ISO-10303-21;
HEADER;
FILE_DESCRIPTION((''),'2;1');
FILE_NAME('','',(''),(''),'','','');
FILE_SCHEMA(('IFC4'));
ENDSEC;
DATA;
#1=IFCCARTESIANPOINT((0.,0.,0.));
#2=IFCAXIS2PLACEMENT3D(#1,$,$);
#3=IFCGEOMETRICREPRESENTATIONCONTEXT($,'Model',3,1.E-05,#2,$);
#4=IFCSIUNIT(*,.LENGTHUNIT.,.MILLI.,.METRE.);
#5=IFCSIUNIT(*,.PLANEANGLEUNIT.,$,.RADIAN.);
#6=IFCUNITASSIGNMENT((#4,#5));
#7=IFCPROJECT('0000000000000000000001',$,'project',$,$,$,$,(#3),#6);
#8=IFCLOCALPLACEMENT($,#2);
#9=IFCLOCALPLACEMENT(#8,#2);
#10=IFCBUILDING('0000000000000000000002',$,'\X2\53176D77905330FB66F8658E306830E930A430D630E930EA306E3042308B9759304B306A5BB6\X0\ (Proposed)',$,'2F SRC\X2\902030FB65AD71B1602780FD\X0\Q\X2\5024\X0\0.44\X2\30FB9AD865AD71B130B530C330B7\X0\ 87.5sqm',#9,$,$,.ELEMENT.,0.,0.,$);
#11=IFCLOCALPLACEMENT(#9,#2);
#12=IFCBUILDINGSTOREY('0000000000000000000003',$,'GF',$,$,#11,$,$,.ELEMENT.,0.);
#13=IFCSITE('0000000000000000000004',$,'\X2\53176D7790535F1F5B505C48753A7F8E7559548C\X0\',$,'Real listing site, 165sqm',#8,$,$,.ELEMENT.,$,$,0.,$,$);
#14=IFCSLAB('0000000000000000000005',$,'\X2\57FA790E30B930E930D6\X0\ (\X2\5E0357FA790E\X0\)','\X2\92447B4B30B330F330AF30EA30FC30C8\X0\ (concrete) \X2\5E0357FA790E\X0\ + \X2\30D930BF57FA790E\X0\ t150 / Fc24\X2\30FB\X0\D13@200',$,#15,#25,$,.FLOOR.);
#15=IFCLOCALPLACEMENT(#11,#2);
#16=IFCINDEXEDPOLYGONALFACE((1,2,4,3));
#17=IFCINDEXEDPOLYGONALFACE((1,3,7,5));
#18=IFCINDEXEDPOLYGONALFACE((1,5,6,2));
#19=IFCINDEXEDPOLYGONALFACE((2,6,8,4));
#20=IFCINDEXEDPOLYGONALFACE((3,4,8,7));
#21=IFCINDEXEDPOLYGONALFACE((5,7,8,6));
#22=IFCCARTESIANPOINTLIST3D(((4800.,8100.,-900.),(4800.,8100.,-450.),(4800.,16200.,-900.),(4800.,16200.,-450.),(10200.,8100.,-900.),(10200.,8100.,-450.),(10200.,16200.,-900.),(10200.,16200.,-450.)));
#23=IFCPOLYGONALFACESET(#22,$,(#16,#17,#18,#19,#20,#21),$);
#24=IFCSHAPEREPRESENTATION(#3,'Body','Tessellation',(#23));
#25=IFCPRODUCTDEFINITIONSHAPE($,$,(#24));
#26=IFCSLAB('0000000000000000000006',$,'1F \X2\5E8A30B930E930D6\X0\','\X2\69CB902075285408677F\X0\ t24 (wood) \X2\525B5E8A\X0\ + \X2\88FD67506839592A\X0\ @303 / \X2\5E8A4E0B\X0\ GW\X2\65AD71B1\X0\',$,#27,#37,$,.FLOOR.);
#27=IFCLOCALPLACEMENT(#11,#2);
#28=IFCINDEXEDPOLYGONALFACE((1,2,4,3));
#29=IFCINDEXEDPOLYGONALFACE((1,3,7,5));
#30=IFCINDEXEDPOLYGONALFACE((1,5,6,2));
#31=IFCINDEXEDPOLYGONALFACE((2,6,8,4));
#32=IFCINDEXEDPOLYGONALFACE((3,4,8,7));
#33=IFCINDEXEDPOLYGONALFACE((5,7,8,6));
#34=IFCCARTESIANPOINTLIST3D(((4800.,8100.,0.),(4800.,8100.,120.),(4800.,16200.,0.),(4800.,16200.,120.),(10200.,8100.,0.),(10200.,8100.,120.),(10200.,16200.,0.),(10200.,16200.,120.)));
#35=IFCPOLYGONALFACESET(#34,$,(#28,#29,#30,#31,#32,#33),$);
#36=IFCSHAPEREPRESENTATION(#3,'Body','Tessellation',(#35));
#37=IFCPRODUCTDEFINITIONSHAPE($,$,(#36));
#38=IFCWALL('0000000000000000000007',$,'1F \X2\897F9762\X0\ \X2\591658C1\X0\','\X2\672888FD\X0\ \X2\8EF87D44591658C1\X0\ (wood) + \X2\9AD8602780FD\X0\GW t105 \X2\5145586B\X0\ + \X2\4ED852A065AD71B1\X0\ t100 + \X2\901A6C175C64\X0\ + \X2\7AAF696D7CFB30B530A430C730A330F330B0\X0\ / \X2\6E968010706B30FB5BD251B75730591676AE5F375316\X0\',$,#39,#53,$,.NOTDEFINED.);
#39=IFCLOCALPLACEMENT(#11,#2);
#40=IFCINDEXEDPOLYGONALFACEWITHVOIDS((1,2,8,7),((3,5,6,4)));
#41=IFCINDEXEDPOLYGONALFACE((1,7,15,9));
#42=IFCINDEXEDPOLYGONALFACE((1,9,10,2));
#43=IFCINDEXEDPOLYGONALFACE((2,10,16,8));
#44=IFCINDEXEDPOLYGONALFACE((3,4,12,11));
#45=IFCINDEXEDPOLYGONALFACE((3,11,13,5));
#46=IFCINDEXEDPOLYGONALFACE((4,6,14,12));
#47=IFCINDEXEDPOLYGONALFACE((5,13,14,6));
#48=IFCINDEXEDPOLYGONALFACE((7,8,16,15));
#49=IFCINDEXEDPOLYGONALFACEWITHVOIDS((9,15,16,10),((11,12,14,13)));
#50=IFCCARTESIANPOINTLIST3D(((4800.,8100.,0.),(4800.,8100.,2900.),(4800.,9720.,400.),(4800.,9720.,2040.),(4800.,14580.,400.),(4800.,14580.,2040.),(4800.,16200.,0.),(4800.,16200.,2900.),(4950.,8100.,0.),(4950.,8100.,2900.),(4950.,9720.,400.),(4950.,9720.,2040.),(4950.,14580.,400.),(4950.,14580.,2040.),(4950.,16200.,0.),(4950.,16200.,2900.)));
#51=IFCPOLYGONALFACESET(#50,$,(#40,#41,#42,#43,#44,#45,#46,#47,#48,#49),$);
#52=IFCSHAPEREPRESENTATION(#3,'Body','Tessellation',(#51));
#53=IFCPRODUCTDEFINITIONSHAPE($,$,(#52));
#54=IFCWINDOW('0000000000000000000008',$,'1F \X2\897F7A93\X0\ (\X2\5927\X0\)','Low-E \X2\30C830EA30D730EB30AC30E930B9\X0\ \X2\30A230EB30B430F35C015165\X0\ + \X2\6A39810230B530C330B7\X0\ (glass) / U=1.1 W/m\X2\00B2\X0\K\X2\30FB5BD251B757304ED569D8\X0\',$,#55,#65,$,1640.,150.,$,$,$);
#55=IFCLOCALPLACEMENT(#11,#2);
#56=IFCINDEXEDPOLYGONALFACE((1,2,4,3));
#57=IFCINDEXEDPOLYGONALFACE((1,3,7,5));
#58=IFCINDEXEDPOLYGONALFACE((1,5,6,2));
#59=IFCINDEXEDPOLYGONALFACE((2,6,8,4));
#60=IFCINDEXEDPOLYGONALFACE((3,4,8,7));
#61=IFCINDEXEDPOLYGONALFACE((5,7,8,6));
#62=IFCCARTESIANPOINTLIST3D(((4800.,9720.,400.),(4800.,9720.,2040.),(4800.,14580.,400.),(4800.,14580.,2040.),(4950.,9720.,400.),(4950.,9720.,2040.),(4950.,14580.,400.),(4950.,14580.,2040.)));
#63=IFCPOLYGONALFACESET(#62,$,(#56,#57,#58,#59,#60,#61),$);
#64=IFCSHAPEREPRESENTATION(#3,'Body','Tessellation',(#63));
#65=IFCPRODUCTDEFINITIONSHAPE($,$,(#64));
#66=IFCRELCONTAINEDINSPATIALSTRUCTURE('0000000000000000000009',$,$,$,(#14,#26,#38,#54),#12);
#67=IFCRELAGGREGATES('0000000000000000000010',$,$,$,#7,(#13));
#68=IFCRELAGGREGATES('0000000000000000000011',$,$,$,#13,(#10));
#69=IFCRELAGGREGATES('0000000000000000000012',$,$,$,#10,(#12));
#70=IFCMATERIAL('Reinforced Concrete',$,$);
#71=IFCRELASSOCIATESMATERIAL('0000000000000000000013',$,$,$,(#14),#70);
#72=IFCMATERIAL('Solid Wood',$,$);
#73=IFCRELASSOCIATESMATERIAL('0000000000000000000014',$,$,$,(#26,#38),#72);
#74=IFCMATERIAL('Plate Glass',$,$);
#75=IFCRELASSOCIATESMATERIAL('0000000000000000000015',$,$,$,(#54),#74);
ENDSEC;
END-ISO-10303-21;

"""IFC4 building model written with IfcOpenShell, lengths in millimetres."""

from ifc_helpers import new_model, si_unit, frame, frame_2d, origin, place, context, project, spatial, rectangle, extrude, material, element, fill, save


model = new_model("IFC4")

# Units and contexts
model_context = context("Model", 3, precision=1e-05, world=origin())
ifc_project = project(units=[si_unit("LENGTHUNIT", "METRE", prefix="MILLI"), si_unit("PLANEANGLEUNIT", "RADIAN")], contexts=[model_context])

# Site, building, storey
site_placement = place(None, origin())
site = spatial("IfcSite", under=ifc_project, at=site_placement, Name="北海道弟子屈町美留和", ObjectType="Real listing site, 165sqm", CompositionType="ELEMENT", RefElevation=0.0)
building_placement = place(site_placement, origin())
building = spatial("IfcBuilding", under=site, at=building_placement, Name="北海道・書斎とライブラリのある静かな家 (Proposed)", ObjectType="2F SRC造・断熱性能Q値0.44・高断熱サッシ 87.5sqm", CompositionType="ELEMENT", ElevationOfRefHeight=0.0, ElevationOfTerrain=0.0)
storey_placement = place(building_placement, origin())
storey = spatial("IfcBuildingStorey", under=building, at=storey_placement, Name="GF", CompositionType="ELEMENT", Elevation=0.0)

# Shared definitions
ifc_material_1 = material(Name="Solid Wood")

# Slabs
ifc_material_2 = material(Name="Reinforced Concrete")
slab_1_placement = place(storey_placement, frame((2400.0, 4050.0, -450.0)))
element("IfcSlab", 1, at=slab_1_placement, inside=storey, material=ifc_material_2, Name="基礎スラブ (布基礎)", Description="鉄筋コンクリート (concrete) 布基礎 + ベタ基礎 t150 / Fc24・D13@200", PredefinedType="FLOOR", context=model_context, shape_type="SweptSolid", body=[
    extrude(rectangle(XDim=5400.0, YDim=8100.0, at=frame_2d((2700.0, 4050.0))), frame((2400.0, 4050.0, -450.0)), (0.0, 0.0, 1.0), 450.0),
])
slab_2_placement = place(storey_placement, frame((2400.0, 4050.0, 0.0)))
element("IfcSlab", 2, at=slab_2_placement, inside=storey, material=ifc_material_1, Name="1F 床スラブ", Description="構造用合板 t24 (wood) 剛床 + 製材根太 @303 / 床下 GW断熱", PredefinedType="FLOOR", context=model_context, shape_type="SweptSolid", body=[
    extrude(rectangle(XDim=5400.0, YDim=8100.0, at=frame_2d((2700.0, 4050.0))), frame((2400.0, 4050.0, 0.0)), (0.0, 0.0, 1.0), 120.0),
])

# Shared definitions
ifc_material_3 = material(Name="Plate Glass")

# Wall, opening, window
wall_1_placement = place(storey_placement, frame((2400.0, 4050.0, 0.0)))
wall_1 = element("IfcWall", 3, at=wall_1_placement, inside=storey, material=ifc_material_1, Name="1F 西面 外壁", Description="木製 軸組外壁 (wood) + 高性能GW t105 充填 + 付加断熱 t100 + 通気層 + 窯業系サイディング / 準耐火・寒冷地外皮強化", PredefinedType="NOTDEFINED", context=model_context, shape_type="SweptSolid", body=[
    extrude(rectangle(XDim=150.0, YDim=8100.0, at=frame_2d((75.0, 4050.0))), frame((2400.0, 4050.0, 0.0)), (0.0, 0.0, 1.0), 2900.0),
])
opening_1_placement = place(storey_placement, frame((2400.0, 4860.0, 200.0)))
opening_1 = element("IfcOpeningElement", 4, at=opening_1_placement, cuts=wall_1, PredefinedType="NOTDEFINED", context=model_context, shape_type="SweptSolid", body=[
    extrude(rectangle(XDim=150.0, YDim=4860.0, at=frame_2d((75.0, 2430.0))), frame((2400.0, 4860.0, 200.0)), (0.0, 0.0, 1.0), 1640.0),
])
window_1_placement = place(storey_placement, frame((2400.0, 4860.0, 200.0)))
window_1 = element("IfcWindow", 5, at=window_1_placement, inside=storey, material=ifc_material_3, Name="1F 西窓 (大)", Description="Low-E トリプルガラス アルゴン封入 + 樹脂サッシ (glass) / U=1.1 W/m²K・寒冷地仕様", OverallHeight=1640.0, OverallWidth=150.0, context=model_context, shape_type="SweptSolid", body=[
    extrude(rectangle(XDim=150.0, YDim=4860.0, at=frame_2d((75.0, 2430.0))), frame((2400.0, 4860.0, 200.0)), (0.0, 0.0, 1.0), 1640.0),
])
fill(opening_1, window_1)

save(model, "model.ifc")
